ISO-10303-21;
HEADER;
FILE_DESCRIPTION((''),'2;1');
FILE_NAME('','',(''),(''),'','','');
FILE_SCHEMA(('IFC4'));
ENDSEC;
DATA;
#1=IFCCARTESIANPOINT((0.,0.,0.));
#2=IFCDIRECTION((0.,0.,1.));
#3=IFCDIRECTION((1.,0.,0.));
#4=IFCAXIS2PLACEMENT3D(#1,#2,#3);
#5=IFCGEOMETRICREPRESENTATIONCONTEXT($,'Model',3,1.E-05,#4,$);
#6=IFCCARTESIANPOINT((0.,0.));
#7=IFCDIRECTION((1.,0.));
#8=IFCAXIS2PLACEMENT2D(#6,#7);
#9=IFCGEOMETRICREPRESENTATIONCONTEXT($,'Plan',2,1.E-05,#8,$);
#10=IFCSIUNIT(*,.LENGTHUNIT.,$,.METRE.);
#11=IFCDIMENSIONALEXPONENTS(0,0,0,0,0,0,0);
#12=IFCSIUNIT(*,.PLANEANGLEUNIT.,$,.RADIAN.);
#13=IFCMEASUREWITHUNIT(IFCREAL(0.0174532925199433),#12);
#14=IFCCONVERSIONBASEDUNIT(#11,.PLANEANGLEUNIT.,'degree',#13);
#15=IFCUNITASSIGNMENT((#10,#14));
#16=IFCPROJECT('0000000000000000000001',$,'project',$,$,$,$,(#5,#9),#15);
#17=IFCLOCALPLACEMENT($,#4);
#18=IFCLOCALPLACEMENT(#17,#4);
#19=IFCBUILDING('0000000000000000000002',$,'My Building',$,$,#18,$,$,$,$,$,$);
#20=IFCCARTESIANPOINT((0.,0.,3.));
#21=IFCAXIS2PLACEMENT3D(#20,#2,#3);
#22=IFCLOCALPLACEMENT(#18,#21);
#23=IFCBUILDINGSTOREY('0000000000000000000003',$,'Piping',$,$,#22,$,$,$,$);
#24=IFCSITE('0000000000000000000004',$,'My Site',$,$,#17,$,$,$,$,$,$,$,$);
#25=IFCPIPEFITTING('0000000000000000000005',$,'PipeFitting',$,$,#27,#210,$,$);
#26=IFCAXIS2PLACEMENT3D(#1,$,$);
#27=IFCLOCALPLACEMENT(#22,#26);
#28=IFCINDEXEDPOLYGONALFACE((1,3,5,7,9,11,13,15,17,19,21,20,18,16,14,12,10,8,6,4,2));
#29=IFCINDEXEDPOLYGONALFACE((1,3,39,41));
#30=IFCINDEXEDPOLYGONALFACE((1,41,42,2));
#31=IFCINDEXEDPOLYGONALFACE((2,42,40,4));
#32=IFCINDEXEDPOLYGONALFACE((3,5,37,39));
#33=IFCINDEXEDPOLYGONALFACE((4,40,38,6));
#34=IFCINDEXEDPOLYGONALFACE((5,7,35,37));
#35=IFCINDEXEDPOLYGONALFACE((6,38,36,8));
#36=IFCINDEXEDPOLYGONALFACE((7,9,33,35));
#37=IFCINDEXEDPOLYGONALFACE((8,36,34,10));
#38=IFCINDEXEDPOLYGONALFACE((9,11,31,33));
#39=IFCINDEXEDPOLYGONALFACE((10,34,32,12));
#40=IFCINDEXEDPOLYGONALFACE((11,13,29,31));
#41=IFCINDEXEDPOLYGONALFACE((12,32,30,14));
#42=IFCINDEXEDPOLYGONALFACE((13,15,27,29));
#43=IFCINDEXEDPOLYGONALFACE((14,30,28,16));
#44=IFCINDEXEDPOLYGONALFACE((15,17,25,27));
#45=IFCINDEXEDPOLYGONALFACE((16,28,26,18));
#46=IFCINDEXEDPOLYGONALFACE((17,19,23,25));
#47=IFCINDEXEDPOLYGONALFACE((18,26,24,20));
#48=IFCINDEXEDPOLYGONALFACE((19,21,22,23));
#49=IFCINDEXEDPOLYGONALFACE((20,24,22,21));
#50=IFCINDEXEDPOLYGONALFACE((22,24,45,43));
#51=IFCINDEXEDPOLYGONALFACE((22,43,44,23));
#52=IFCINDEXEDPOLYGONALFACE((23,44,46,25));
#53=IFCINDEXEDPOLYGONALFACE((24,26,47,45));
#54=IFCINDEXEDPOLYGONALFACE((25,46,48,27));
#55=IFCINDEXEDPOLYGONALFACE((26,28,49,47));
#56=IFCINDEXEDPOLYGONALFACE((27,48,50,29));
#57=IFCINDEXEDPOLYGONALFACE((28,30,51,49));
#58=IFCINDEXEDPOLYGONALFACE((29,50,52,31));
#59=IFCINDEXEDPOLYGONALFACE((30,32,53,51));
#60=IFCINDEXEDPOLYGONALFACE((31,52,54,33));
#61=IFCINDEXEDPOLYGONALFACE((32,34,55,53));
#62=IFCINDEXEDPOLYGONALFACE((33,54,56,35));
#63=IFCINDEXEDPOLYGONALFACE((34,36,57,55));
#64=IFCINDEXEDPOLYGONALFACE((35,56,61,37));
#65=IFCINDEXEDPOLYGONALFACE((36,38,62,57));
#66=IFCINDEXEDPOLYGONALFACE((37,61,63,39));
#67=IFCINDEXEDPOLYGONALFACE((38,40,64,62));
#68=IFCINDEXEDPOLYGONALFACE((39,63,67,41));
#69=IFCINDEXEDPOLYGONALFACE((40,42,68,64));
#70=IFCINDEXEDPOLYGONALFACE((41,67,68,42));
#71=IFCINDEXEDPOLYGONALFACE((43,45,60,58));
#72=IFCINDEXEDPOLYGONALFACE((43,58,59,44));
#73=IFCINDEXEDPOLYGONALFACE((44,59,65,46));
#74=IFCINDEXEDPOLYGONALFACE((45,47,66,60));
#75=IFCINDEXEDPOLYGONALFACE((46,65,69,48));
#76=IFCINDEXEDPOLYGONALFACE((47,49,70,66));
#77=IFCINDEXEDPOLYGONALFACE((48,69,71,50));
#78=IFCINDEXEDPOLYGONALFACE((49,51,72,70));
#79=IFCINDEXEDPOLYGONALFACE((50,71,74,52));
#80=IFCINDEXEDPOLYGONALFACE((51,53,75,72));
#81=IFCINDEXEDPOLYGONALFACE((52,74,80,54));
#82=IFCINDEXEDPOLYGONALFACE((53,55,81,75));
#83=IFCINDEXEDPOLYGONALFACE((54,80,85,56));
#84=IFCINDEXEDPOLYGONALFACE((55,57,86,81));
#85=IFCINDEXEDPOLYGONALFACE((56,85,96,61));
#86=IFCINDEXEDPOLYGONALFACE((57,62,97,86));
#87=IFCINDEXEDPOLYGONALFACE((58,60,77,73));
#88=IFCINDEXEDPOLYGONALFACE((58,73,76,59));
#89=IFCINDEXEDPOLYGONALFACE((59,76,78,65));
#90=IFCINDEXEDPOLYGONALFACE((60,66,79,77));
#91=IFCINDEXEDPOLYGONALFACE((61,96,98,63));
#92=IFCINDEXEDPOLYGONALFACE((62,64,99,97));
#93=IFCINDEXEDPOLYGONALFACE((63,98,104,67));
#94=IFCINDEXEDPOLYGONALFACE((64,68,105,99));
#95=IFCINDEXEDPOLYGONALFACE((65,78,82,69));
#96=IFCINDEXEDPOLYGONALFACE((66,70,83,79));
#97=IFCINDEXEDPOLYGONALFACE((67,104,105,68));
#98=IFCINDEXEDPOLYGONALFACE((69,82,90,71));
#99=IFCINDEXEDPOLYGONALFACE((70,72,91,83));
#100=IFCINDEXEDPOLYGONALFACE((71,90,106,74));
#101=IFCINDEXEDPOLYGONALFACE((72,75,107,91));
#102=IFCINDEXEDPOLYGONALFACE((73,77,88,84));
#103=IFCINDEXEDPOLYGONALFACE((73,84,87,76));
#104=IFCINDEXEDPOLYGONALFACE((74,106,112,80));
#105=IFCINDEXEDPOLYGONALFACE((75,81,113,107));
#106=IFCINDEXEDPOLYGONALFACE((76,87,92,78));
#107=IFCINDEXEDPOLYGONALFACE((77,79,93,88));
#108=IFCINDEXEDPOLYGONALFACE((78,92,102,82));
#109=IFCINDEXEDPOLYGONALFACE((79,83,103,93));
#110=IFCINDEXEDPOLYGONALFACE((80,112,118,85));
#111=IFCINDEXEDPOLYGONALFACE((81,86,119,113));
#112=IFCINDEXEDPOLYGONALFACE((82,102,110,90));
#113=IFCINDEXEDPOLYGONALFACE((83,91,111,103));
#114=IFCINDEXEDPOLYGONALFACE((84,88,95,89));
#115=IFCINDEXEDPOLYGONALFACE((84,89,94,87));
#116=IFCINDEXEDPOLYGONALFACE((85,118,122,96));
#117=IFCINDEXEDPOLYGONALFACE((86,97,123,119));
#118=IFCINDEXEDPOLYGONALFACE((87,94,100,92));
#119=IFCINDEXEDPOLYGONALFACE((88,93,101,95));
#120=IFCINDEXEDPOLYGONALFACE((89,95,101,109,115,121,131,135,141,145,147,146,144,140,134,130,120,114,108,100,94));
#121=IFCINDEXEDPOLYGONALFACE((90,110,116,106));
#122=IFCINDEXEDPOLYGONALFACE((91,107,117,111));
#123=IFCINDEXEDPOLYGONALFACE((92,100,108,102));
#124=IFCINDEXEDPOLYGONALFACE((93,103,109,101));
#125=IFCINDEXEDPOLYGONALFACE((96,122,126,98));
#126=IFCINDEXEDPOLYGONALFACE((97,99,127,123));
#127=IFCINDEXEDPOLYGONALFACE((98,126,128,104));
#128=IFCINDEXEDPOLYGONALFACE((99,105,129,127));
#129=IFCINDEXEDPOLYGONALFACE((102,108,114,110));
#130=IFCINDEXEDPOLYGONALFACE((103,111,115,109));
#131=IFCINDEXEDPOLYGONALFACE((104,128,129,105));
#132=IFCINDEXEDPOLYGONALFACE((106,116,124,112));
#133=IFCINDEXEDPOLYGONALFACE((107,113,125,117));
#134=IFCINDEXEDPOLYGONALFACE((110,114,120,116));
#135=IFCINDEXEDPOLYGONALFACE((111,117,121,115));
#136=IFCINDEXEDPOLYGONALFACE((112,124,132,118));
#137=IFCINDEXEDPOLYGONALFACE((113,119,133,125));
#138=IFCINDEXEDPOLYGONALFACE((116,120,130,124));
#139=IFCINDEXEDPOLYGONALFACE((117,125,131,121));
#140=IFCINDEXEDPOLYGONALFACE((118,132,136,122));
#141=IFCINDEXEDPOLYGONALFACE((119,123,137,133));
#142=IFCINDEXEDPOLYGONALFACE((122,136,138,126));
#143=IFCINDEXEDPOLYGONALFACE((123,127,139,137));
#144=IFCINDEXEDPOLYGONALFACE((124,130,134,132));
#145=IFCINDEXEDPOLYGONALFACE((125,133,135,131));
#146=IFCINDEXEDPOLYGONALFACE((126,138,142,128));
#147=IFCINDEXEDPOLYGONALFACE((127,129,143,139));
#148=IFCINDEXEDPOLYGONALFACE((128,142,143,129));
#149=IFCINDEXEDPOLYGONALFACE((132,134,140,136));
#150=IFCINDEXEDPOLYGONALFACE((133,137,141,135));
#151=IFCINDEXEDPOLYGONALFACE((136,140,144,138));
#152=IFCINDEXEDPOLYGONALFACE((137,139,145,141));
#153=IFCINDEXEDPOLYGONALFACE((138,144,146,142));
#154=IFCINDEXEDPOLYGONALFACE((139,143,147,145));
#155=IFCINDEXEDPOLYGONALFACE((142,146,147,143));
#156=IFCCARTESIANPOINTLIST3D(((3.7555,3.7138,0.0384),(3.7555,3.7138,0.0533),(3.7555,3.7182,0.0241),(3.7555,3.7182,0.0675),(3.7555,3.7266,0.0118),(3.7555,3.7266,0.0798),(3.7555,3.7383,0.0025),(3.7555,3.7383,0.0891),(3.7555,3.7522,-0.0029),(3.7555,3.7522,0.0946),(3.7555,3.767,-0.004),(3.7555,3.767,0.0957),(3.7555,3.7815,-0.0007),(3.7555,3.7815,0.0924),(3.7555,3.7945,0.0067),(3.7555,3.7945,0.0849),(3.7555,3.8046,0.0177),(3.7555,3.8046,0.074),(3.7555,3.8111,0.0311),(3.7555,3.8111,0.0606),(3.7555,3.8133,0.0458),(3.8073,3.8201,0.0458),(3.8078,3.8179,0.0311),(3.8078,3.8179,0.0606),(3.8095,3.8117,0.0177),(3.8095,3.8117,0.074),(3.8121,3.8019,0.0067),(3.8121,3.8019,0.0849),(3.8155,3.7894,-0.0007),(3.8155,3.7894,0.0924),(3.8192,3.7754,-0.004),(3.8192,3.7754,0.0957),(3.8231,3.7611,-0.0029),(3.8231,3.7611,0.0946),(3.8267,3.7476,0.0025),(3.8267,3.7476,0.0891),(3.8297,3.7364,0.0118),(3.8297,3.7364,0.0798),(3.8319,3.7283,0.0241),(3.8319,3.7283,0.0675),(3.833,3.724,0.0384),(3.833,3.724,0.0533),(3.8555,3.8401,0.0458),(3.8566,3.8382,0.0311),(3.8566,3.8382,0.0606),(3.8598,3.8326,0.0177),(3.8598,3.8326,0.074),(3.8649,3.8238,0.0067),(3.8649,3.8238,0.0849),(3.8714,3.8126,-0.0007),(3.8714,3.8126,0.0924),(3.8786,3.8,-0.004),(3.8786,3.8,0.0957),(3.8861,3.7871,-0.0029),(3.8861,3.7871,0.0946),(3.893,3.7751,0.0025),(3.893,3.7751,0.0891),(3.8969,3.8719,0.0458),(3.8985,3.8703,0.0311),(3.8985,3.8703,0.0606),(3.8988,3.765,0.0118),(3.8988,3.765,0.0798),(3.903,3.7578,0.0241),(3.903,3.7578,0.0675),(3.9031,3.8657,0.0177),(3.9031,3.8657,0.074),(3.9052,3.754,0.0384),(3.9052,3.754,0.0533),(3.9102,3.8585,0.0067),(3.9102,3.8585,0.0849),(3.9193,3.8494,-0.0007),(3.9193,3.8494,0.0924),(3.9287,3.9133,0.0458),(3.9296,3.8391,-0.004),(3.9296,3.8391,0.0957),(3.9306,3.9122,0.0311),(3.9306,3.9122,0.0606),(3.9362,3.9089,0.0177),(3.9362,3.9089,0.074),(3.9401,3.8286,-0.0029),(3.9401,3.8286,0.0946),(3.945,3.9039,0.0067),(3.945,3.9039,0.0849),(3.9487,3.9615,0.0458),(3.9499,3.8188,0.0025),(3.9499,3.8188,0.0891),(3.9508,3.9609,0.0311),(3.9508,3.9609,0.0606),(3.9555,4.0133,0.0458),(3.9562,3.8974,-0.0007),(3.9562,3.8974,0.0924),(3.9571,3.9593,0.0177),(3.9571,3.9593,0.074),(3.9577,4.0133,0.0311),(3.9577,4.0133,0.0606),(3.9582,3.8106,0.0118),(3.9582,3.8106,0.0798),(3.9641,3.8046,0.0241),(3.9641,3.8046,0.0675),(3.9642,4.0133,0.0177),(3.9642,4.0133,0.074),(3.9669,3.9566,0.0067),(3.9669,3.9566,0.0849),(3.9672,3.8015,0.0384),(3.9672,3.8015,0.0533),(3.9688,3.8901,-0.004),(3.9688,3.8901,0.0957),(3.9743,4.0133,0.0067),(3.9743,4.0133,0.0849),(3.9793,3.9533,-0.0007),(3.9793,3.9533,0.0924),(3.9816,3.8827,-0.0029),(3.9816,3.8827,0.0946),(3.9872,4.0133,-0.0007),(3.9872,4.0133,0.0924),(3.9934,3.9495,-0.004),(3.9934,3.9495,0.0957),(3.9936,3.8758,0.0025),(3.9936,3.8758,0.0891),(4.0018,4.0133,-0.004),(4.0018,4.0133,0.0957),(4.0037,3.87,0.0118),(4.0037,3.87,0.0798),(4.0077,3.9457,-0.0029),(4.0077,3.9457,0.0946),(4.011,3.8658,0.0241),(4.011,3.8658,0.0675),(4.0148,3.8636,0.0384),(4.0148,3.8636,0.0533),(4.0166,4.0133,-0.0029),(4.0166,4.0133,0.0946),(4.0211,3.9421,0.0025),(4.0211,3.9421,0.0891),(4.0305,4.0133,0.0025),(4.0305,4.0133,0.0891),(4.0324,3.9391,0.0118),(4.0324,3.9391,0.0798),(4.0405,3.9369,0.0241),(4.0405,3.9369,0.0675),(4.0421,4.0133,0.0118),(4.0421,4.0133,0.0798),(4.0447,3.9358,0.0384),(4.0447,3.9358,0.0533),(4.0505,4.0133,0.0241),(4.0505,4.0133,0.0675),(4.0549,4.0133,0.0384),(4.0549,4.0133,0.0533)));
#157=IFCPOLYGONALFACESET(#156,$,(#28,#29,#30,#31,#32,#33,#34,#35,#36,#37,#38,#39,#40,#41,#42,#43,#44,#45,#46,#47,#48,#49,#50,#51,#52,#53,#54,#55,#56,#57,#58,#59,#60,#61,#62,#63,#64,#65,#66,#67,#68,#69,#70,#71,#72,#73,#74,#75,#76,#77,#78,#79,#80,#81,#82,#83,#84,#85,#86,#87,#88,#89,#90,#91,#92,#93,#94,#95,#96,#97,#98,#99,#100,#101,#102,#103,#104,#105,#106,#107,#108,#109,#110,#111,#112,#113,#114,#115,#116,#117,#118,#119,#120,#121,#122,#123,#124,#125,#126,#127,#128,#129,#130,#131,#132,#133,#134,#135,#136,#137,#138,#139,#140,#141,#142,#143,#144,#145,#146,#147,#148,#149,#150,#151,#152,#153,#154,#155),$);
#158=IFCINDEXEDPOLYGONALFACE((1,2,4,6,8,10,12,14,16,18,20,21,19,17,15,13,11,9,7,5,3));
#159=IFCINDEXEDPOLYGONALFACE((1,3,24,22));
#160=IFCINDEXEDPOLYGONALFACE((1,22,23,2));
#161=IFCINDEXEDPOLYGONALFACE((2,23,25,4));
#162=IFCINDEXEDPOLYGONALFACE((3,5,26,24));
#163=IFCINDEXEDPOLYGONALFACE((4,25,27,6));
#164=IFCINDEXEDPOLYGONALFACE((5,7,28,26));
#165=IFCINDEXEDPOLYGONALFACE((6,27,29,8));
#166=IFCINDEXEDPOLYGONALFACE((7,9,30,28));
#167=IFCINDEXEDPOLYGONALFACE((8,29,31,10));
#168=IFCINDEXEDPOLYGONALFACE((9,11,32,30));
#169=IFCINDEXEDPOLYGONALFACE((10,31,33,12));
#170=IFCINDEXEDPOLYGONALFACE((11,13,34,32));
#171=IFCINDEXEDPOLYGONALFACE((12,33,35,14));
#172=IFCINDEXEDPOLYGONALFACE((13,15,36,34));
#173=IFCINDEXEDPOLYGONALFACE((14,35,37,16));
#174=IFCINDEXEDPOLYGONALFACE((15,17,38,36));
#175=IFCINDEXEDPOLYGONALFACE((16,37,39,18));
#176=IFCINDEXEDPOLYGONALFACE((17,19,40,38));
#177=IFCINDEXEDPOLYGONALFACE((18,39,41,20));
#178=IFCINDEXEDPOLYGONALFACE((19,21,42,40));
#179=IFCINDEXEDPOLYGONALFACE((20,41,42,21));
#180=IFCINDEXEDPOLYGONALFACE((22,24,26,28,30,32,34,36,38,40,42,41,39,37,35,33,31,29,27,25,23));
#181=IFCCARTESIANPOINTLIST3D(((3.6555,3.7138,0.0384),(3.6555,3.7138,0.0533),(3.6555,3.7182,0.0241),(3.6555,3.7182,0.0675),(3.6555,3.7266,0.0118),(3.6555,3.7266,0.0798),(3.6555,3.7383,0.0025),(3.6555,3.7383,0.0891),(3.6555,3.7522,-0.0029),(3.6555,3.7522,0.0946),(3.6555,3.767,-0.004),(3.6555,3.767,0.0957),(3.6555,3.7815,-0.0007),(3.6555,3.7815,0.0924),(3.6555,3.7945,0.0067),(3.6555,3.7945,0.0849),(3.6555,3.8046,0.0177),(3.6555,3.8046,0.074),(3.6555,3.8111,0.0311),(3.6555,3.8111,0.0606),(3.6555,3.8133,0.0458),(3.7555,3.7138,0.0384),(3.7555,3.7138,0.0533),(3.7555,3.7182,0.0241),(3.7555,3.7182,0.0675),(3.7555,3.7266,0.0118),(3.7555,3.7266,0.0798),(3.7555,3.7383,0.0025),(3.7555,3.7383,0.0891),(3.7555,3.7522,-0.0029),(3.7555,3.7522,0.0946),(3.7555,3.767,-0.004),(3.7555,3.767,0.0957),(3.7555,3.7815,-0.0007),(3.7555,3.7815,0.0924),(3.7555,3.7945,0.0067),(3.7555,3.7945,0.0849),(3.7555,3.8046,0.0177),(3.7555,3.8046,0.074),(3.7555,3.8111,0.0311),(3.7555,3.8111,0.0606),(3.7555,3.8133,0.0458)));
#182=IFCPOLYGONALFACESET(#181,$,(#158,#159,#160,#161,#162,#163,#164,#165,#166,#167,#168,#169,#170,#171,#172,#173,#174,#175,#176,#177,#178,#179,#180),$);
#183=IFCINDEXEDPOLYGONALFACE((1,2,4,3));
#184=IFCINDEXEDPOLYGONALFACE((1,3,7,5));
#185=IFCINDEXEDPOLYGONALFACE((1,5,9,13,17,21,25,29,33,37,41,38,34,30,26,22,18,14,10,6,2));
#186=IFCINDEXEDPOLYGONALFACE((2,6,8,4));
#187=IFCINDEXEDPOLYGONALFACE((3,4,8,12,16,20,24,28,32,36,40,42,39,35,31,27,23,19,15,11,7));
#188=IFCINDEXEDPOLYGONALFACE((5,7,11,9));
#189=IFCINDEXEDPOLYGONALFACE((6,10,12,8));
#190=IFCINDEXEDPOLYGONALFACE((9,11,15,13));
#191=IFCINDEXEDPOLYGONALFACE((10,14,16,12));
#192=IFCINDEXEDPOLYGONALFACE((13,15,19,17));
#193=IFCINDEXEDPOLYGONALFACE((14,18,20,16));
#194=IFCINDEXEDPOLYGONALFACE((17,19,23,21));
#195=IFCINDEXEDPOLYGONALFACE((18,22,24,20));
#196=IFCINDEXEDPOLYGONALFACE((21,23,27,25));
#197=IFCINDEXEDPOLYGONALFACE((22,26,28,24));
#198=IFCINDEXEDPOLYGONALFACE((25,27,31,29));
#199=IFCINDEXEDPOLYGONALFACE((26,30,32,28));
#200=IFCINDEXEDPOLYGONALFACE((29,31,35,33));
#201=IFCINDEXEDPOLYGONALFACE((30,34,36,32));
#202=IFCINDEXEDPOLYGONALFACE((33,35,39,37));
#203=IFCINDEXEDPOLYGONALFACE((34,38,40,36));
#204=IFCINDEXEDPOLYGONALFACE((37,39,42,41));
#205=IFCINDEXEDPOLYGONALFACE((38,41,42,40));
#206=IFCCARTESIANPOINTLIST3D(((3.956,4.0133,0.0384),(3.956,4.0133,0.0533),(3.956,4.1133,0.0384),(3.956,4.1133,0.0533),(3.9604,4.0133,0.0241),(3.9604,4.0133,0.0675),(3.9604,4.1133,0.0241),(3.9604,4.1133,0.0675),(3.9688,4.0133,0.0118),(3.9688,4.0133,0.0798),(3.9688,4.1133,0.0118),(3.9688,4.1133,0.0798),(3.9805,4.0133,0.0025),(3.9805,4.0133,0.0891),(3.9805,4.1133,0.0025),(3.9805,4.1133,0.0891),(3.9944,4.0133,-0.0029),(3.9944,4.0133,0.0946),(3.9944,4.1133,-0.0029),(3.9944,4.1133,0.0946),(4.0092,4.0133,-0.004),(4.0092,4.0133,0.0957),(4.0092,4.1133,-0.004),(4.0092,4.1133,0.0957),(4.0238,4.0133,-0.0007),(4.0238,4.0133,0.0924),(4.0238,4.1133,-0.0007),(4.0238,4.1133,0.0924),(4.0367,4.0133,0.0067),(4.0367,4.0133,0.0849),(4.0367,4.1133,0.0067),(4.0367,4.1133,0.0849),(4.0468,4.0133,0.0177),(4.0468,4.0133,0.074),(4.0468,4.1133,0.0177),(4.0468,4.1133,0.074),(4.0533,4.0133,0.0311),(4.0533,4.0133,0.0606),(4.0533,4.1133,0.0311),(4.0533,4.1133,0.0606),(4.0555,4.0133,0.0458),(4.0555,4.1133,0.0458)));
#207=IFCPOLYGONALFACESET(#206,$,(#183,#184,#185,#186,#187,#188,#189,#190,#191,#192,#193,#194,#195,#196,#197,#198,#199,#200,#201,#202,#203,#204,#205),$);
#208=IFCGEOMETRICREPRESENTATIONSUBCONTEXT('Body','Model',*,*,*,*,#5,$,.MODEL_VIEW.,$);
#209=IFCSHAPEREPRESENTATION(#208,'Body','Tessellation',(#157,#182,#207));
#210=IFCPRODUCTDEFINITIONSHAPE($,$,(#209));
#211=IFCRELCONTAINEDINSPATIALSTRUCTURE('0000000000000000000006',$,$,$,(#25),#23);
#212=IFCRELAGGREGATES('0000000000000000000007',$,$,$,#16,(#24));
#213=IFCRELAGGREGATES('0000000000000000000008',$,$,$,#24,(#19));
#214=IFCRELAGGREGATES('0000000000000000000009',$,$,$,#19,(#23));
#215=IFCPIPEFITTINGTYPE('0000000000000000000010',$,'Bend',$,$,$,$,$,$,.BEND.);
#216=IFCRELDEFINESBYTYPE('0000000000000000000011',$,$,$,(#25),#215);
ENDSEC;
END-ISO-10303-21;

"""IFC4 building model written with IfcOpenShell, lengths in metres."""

from ifc_helpers import new_model, entity, si_unit, converted_unit, frame, origin_with_axes, origin_2d_with_axis, place, context, subcontext, project, spatial, circle, extrude, source, transform, mapped, type_object, type_shapes, element, save


model = new_model("IFC4")

# Units and contexts
model_context = context("Model", 3, precision=1e-05, world=origin_with_axes())
plan_context = context("Plan", 2, precision=1e-05, world=origin_2d_with_axis())
body_context = subcontext(model_context, "Body", "Model", "MODEL_VIEW")
ifc_project = project(units=[si_unit("LENGTHUNIT", "METRE"), converted_unit("PLANEANGLEUNIT", "degree", entity("IfcReal", 0.0174532925199433), si_unit("PLANEANGLEUNIT", "RADIAN"), dimensions=[0, 0, 0, 0, 0, 0, 0])], contexts=[model_context, plan_context])

# Site, building, storey
site_placement = place(None, origin_with_axes())
site = spatial("IfcSite", under=ifc_project, at=site_placement, Name="My Site")
building_placement = place(site_placement, origin_with_axes())
building = spatial("IfcBuilding", under=site, at=building_placement, Name="My Building")
storey_placement = place(building_placement, frame((0.0, 0.0, 3.0), z_axis=(0.0, 0.0, 1.0), x_axis=(1.0, 0.0, 0.0)))
storey = spatial("IfcBuildingStorey", under=building, at=storey_placement, Name="Piping")

# Pipe fitting
pipe_fitting_type_1 = type_object("IfcPipeFittingType", Name="Bend", PredefinedType="BEND")
shared_shape_1 = source(origin_with_axes(), body_context, "Body", "SolidModel", [
    entity("IfcSweptDiskSolid", entity("IfcIndexedPolyCurve", entity("IfcCartesianPointList3D", [[0.0, 0.0, 0.1], [0.0732, 0.0, 0.2768], [0.25, 0.0, 0.35]]), [entity("IfcArcIndex", [1, 2, 3])]), 0.05),
    extrude(circle(Radius=0.05), origin_with_axes(), (0.0, 0.0, 1.0), 0.1),
    extrude(circle(Radius=0.05), frame((0.25, 0.0, 0.35), z_axis=(1.0, 0.0, 0.0), x_axis=(0.0, 0.0, 1.0)), (0.0, 0.0, 1.0), 0.1),
])
type_shapes(pipe_fitting_type_1, [shared_shape_1])
for number, where, z_axis, x_axis, name in (
    (1, (3.6555, 3.7633, 0.0458), (1.0, 0.0, 0.0), (0.0, 1.0, 0.0), "PipeFitting"),
):
    element("IfcPipeFitting", number, at=place(storey_placement, frame(where, z_axis=z_axis, x_axis=x_axis)), inside=storey, type_object=pipe_fitting_type_1, Name=name, context=body_context, shape_type="MappedRepresentation", body=[
        mapped(shared_shape_1, transform((0.0, 0.0, 0.0), x_axis=(1.0, 0.0, 0.0), y_axis=(0.0, 1.0, 0.0), z_axis=(0.0, 0.0, 1.0), scale=1.0)),
    ])

save(model, "model.ifc")
